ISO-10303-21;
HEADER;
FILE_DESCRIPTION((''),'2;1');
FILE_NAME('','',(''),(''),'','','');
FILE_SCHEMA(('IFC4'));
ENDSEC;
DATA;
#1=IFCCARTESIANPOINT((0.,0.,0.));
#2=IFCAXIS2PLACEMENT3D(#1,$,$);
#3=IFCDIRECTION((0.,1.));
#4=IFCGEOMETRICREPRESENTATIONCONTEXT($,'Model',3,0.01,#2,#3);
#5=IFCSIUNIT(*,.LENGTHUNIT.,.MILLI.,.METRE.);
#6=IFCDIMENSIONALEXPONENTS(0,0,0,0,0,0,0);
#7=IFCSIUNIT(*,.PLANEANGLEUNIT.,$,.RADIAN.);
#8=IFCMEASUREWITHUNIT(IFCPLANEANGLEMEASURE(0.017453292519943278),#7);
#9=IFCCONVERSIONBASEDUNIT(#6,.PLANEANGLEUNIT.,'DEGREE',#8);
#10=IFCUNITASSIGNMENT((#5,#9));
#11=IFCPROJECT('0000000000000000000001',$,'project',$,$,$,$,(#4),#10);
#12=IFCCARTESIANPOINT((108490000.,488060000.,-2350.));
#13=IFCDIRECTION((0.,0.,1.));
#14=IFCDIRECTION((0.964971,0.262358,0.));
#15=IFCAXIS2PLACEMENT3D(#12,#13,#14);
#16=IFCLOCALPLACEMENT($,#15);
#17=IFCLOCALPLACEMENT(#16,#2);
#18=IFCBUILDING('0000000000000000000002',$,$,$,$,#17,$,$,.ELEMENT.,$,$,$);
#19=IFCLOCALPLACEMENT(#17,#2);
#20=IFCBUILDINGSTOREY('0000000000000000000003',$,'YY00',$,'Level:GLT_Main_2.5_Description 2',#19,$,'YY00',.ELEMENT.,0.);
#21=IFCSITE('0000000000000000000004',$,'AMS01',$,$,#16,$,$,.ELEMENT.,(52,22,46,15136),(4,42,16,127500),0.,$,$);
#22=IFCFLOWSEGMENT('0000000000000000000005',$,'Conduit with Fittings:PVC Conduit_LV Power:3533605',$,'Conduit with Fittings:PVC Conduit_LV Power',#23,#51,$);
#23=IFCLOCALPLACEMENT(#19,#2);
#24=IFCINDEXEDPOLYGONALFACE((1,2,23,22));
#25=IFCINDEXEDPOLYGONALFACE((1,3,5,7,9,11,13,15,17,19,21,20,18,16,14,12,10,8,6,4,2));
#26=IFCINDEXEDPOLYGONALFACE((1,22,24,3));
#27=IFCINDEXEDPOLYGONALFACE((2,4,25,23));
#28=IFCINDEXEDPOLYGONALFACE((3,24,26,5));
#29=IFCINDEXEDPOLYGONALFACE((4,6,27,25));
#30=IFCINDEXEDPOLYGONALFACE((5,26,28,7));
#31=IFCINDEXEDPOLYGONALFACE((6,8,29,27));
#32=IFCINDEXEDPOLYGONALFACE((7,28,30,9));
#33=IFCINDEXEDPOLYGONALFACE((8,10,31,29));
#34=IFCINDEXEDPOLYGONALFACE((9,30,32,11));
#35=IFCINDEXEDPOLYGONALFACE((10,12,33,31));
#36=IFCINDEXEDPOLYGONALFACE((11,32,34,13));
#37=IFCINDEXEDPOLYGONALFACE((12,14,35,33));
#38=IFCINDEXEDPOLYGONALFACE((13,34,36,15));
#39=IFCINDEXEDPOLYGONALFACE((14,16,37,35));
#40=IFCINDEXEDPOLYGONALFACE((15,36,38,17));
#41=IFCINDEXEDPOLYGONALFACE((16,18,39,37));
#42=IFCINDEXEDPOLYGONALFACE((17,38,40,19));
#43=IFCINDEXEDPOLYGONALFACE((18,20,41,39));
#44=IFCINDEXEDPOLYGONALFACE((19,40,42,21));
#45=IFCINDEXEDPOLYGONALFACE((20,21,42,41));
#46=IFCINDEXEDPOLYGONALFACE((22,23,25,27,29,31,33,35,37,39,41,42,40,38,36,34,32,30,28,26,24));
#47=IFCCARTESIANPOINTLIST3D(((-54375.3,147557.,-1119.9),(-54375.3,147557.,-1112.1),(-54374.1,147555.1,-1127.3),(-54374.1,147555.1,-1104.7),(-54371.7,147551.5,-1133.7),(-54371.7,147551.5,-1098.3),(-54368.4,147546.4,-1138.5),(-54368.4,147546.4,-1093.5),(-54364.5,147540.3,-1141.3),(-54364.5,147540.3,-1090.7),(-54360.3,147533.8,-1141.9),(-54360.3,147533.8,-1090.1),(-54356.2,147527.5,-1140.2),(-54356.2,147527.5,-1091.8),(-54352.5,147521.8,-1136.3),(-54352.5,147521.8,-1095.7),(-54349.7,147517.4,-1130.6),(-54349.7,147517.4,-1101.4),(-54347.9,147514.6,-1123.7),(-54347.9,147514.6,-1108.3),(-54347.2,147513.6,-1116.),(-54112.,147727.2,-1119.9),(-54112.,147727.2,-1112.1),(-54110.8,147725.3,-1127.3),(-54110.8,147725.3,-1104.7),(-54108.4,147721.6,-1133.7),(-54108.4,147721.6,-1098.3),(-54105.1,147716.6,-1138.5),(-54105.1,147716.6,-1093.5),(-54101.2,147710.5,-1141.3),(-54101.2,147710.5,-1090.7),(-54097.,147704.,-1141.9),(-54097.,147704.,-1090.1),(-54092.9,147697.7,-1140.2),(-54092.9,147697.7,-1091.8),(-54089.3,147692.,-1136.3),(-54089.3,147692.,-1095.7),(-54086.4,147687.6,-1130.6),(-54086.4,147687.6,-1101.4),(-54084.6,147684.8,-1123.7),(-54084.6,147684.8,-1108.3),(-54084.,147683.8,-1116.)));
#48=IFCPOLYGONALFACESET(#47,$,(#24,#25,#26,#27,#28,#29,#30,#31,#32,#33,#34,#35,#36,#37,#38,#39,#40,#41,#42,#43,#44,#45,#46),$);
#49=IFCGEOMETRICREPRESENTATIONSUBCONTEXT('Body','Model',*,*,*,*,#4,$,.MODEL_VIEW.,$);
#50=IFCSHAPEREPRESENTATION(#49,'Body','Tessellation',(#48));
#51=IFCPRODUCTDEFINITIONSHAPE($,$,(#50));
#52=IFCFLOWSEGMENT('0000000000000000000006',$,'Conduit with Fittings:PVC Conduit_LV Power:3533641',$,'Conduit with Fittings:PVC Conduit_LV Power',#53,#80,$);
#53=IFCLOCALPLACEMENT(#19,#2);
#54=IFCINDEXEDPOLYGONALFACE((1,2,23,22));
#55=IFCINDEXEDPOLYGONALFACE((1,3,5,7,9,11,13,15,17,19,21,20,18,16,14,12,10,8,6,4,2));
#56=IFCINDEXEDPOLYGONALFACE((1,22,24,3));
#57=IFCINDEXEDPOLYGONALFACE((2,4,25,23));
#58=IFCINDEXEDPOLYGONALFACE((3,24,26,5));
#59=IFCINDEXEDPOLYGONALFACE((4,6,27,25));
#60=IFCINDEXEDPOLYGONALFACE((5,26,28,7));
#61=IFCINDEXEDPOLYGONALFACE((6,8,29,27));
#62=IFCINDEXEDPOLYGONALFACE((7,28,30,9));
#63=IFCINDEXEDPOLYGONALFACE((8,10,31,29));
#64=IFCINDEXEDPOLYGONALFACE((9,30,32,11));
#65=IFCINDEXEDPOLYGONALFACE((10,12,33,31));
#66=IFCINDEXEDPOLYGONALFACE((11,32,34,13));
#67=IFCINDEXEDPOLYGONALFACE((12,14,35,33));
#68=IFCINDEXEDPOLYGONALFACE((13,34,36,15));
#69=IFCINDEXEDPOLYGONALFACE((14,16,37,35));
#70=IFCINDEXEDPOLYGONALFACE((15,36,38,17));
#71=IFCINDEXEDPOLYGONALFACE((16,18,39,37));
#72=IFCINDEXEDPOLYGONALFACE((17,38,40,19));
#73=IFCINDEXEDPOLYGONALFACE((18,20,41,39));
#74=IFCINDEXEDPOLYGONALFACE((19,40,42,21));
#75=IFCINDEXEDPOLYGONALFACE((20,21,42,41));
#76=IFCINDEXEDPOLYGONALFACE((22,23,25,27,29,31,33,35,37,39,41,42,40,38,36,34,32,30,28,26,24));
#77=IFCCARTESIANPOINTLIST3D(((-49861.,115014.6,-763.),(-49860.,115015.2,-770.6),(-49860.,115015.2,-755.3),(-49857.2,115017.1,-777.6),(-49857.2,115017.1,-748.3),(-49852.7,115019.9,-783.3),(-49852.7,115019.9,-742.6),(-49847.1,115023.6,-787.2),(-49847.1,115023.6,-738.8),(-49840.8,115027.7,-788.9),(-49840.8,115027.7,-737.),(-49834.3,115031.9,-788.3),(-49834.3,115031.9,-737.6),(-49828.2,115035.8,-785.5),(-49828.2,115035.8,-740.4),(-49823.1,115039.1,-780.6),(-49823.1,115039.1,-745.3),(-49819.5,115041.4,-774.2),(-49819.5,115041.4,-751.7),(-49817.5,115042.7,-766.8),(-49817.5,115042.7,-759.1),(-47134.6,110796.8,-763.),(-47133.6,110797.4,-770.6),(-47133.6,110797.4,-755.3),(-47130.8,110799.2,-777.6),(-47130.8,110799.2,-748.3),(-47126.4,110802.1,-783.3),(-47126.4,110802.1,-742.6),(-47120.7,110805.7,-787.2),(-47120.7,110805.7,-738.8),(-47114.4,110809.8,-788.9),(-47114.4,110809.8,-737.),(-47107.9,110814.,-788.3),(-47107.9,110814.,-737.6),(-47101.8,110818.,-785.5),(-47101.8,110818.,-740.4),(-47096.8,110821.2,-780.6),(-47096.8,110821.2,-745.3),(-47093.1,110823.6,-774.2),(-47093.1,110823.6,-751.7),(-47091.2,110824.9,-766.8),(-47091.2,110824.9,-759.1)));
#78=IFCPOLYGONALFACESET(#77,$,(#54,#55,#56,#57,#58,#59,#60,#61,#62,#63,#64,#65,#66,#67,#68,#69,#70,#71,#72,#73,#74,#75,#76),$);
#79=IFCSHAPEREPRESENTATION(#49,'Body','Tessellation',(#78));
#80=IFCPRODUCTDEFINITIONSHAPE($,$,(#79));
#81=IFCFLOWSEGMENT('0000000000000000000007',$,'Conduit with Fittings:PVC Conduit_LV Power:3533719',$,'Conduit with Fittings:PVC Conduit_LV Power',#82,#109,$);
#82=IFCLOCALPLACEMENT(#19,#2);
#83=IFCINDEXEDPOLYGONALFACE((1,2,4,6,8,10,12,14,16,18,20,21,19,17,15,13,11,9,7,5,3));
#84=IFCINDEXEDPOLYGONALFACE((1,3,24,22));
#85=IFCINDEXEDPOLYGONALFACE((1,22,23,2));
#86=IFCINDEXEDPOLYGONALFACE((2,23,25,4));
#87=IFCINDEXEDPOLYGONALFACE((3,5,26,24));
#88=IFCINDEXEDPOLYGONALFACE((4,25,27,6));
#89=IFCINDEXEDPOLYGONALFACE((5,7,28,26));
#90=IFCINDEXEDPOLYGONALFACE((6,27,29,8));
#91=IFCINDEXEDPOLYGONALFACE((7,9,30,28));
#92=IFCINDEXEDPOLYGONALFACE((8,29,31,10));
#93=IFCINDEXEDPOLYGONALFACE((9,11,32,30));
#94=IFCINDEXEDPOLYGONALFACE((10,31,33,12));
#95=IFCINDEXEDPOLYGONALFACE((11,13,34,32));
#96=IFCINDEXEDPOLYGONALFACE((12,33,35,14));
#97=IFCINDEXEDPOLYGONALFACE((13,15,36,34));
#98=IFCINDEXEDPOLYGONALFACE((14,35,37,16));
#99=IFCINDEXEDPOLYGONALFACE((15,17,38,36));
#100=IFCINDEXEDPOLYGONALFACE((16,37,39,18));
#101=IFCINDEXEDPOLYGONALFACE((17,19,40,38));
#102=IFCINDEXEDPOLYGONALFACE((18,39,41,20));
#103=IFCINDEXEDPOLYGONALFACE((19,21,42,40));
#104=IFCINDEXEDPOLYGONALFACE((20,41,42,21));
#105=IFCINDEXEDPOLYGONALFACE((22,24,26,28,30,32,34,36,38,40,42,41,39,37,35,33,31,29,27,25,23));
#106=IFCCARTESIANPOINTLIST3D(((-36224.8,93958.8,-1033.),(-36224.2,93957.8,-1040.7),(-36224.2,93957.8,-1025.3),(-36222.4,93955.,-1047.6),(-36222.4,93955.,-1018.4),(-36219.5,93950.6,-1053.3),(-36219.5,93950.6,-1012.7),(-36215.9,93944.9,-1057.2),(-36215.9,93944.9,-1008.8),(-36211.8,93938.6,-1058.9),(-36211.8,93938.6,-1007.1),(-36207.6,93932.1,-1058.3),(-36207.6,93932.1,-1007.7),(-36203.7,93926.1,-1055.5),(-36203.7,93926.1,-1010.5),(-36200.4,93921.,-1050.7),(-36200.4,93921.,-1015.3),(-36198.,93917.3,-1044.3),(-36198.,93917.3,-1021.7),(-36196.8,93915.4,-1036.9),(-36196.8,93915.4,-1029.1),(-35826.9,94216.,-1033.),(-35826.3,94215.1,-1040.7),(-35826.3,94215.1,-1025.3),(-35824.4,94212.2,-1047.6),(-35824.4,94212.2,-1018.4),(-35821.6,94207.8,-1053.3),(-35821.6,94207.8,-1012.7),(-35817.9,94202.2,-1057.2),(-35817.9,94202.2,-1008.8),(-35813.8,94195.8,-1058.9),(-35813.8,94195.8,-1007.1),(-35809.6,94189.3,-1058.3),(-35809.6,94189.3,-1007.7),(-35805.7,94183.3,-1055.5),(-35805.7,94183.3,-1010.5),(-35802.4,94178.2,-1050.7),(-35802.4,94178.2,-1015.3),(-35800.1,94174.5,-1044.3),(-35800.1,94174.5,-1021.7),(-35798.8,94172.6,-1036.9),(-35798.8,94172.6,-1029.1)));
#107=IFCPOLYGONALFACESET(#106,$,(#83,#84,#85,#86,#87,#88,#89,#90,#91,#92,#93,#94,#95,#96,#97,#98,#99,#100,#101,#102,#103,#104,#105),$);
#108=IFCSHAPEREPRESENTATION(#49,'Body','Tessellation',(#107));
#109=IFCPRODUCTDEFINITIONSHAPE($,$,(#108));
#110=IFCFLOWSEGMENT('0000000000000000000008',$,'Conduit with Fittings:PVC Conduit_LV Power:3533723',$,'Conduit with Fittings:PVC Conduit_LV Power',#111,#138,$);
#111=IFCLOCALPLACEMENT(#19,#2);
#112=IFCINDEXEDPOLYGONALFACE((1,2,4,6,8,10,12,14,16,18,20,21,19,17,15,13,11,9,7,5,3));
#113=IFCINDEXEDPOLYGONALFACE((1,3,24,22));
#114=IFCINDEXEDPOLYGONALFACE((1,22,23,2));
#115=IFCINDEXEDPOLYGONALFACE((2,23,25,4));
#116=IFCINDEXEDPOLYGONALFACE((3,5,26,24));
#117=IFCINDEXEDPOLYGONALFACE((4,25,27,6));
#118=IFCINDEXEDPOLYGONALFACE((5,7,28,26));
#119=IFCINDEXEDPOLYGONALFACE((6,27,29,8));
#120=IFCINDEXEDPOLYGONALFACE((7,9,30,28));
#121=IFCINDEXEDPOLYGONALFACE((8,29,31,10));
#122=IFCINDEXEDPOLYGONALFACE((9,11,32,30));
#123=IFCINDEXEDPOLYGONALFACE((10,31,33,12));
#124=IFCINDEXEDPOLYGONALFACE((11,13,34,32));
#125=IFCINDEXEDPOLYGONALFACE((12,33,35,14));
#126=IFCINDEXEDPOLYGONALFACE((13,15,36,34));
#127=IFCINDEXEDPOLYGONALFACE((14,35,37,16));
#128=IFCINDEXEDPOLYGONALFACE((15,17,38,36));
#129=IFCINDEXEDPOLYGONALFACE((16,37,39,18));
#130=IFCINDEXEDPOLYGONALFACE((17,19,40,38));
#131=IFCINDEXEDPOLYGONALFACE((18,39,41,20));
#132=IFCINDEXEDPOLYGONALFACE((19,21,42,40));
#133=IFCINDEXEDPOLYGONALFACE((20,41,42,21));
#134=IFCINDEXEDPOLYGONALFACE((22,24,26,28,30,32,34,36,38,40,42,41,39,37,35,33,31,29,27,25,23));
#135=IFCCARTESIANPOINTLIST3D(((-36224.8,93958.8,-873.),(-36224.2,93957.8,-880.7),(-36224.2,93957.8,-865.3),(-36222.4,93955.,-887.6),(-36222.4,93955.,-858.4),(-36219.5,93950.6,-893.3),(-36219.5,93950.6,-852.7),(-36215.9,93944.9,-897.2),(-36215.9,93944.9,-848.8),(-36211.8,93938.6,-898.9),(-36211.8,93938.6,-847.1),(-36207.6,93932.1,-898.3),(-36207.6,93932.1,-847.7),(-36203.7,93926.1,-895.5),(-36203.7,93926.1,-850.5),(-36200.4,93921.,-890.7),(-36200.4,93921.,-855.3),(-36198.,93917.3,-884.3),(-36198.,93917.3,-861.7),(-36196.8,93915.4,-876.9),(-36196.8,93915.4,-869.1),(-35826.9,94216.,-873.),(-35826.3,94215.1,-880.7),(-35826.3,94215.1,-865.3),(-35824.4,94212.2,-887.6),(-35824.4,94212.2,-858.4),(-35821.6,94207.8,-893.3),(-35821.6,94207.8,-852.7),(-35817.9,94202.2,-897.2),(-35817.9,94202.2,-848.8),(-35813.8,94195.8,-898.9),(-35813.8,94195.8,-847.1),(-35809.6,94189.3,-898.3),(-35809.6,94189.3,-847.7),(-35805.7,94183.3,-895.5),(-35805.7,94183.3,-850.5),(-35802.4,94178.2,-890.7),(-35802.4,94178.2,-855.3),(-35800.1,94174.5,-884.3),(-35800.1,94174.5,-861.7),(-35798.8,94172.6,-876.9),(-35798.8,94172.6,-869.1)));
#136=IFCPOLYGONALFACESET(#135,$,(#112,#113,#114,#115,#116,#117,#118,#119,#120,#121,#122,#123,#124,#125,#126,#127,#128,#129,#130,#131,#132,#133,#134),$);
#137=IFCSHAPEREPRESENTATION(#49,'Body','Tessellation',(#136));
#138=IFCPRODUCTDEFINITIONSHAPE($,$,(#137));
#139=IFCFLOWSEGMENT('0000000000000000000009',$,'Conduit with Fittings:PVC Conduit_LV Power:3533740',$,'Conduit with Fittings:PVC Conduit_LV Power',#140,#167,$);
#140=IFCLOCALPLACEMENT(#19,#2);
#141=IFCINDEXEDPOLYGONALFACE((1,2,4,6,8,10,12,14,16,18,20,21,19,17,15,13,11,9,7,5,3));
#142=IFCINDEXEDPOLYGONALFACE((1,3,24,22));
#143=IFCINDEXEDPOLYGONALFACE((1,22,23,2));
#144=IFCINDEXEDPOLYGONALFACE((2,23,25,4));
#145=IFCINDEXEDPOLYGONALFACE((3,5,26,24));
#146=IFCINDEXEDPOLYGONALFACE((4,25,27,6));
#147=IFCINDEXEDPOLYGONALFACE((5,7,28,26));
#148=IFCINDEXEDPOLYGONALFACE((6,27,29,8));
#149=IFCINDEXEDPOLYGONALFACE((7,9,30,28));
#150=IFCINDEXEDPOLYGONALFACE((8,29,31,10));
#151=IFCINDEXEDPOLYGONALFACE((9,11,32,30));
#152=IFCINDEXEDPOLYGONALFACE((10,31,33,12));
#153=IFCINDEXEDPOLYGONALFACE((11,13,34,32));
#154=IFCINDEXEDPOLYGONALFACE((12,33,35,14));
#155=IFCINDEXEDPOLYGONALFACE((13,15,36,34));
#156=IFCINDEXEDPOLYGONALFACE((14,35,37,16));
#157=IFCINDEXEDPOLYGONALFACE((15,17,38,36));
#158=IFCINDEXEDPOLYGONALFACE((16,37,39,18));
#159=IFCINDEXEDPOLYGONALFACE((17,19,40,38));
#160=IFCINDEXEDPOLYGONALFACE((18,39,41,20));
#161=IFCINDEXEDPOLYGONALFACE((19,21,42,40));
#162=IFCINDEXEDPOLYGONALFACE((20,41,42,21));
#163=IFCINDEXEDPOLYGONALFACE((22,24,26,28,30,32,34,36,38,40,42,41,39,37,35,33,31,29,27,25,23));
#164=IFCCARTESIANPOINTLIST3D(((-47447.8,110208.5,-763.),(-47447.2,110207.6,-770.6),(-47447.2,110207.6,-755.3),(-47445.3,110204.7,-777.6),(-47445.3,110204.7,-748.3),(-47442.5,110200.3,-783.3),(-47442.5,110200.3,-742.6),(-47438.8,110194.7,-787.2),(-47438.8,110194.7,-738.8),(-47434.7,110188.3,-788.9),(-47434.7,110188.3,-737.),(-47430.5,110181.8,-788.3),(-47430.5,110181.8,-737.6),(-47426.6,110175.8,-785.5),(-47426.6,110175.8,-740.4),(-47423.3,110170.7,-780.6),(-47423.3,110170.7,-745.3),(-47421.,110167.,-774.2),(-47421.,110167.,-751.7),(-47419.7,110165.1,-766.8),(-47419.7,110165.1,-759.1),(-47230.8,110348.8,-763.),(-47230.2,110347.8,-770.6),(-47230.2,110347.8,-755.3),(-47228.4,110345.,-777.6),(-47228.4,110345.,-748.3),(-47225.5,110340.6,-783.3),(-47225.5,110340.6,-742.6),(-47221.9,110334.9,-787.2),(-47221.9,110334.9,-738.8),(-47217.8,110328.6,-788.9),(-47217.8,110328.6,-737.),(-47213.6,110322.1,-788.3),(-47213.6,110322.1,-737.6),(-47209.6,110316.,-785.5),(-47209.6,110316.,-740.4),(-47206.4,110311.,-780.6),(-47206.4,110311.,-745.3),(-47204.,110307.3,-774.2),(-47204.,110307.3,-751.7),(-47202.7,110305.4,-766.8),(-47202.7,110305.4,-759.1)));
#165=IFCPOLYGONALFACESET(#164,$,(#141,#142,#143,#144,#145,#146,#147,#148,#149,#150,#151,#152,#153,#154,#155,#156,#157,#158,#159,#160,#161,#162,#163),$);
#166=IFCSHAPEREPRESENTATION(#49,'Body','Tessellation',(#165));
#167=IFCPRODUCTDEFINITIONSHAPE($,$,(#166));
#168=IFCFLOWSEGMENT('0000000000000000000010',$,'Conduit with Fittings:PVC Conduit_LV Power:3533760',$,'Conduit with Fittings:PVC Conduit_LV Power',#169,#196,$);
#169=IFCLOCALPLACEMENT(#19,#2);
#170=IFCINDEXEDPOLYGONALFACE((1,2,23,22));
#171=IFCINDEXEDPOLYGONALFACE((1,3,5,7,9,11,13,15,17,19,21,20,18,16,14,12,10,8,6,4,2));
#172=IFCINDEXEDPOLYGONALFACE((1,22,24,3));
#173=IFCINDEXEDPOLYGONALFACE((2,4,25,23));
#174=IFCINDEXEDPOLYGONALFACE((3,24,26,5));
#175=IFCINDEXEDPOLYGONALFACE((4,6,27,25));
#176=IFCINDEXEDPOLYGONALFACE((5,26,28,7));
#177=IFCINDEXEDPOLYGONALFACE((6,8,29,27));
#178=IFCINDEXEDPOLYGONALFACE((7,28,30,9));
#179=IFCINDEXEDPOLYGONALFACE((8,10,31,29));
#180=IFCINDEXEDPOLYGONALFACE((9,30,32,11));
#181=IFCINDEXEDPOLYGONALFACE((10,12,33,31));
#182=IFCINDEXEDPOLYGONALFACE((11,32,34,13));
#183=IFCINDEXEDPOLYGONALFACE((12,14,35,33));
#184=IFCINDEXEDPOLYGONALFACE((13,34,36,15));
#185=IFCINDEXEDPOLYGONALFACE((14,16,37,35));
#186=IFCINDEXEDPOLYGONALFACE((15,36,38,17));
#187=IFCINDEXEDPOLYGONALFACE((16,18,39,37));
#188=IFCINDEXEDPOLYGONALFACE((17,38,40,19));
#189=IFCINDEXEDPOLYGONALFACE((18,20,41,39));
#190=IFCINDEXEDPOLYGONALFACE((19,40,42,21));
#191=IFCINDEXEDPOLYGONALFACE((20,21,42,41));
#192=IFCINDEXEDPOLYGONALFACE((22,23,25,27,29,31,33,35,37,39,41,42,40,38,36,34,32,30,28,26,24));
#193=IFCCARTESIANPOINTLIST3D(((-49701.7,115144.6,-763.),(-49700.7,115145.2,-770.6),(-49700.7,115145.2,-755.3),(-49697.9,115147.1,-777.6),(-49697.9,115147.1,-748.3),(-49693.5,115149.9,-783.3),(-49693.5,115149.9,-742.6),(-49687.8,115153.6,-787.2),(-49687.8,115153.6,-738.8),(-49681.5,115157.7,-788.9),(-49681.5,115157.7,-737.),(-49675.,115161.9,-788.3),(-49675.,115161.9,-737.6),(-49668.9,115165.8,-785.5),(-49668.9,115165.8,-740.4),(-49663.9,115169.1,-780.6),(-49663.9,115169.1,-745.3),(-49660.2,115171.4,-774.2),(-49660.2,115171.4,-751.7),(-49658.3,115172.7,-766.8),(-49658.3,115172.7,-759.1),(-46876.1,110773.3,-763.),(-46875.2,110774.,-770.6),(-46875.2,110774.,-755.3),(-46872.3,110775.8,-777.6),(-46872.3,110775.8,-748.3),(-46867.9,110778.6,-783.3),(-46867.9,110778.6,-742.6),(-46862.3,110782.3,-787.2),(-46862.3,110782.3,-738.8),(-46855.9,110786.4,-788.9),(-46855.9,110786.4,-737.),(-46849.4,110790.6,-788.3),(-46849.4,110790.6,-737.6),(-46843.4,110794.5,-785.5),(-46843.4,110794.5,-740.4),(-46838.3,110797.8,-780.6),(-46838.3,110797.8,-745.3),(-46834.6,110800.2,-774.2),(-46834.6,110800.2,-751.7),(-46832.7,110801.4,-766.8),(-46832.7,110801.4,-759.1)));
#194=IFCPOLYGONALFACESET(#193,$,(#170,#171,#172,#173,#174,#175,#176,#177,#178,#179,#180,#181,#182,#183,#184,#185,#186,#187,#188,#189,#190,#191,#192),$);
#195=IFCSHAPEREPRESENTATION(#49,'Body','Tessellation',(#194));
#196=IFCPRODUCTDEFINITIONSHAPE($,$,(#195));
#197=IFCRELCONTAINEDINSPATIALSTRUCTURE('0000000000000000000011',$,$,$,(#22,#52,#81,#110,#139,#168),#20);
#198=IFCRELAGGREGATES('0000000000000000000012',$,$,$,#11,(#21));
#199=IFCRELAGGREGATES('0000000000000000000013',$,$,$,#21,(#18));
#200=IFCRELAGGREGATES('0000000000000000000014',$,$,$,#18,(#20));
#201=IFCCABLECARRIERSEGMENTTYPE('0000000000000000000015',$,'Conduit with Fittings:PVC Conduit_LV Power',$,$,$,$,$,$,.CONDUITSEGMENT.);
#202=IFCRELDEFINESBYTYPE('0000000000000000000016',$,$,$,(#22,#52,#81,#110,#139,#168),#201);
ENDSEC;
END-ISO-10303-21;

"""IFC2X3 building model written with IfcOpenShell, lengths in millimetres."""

from ifc_helpers import new_model, entity, si_unit, converted_unit, direction, frame, frame_2d, origin, origin_2d_with_axis, place, context, subcontext, project, spatial, circle, extrude, type_object, element, save


model = new_model("IFC2X3")

# Units and contexts
model_context = context("Model", 3, precision=0.01, world=origin(), true_north=direction((0.0, 1.0)))
body_context = subcontext(model_context, "Body", "Model", "MODEL_VIEW")
ifc_project = project(units=[si_unit("LENGTHUNIT", "METRE", prefix="MILLI"), converted_unit("PLANEANGLEUNIT", "DEGREE", entity("IfcPlaneAngleMeasure", 0.017453292519943278), si_unit("PLANEANGLEUNIT", "RADIAN"), dimensions=[0, 0, 0, 0, 0, 0, 0])], contexts=[model_context])

# Site, building, storey
site_placement = place(None, frame((108490000.0, 488060000.0, -2350.0), z_axis=(0.0, 0.0, 1.0), x_axis=(0.964971, 0.262358, 0.0)))
site = spatial("IfcSite", under=ifc_project, at=site_placement, Name="AMS01", CompositionType="ELEMENT", RefLatitude=(52, 22, 46, 15136), RefLongitude=(4, 42, 16, 127500), RefElevation=0.0)
building_placement = place(site_placement, origin())
building = spatial("IfcBuilding", under=site, at=building_placement, CompositionType="ELEMENT")
storey_placement = place(building_placement, origin())
storey = spatial("IfcBuildingStorey", under=building, at=storey_placement, Name="YY00", ObjectType="Level:GLT_Main_2.5_Description 2", LongName="YY00", CompositionType="ELEMENT", Elevation=0.0)

# Flow segments
cable_carrier_segment_type = type_object("IfcCableCarrierSegmentType", Name="Conduit with Fittings:PVC Conduit_LV Power", PredefinedType="CONDUITSEGMENT")
flow_segment_1_placement = place(storey_placement, origin())
element("IfcFlowSegment", 1, at=flow_segment_1_placement, inside=storey, type_object=cable_carrier_segment_type, Name="Conduit with Fittings:PVC Conduit_LV Power:3533605", ObjectType="Conduit with Fittings:PVC Conduit_LV Power", context=body_context, shape_type="SweptSolid", body=[
    extrude(circle(Radius=26.0, at=origin_2d_with_axis()), frame((-54361.3, 147535.5, -1116.0), z_axis=(0.839796, 0.542902, 0.0), x_axis=(0.542902, -0.839796, 0.0)), (0.0, 0.0, 1.0), 313.5),
])
flow_segment_2_placement = place(storey_placement, origin())
element("IfcFlowSegment", 2, at=flow_segment_2_placement, inside=storey, type_object=cable_carrier_segment_type, Name="Conduit with Fittings:PVC Conduit_LV Power:3533641", ObjectType="Conduit with Fittings:PVC Conduit_LV Power", context=body_context, shape_type="SweptSolid", body=[
    extrude(circle(Radius=26.0, at=frame_2d((0.0, 0.0), x_axis=(1.0, 0.0))), frame((-47112.8, 110810.9, -763.0), z_axis=(-0.542856, 0.839826, 0.0), x_axis=(-0.839826, -0.542856, 0.0)), (0.0, 0.0, 1.0), 5022.3),
])
flow_segment_3_placement = place(storey_placement, origin())
element("IfcFlowSegment", 3, at=flow_segment_3_placement, inside=storey, type_object=cable_carrier_segment_type, Name="Conduit with Fittings:PVC Conduit_LV Power:3533719", ObjectType="Conduit with Fittings:PVC Conduit_LV Power", context=body_context, shape_type="SweptSolid", body=[
    extrude(circle(Radius=26.0, at=frame_2d((0.0, 0.0), x_axis=(1.0, 0.0))), frame((-36210.7, 93937.0, -1033.0), z_axis=(0.839826, 0.542856, 0.0), x_axis=(-0.542856, 0.839826, 0.0)), (0.0, 0.0, 1.0), 473.8),
])
flow_segment_4_placement = place(storey_placement, origin())
element("IfcFlowSegment", 4, at=flow_segment_4_placement, inside=storey, type_object=cable_carrier_segment_type, Name="Conduit with Fittings:PVC Conduit_LV Power:3533723", ObjectType="Conduit with Fittings:PVC Conduit_LV Power", context=body_context, shape_type="SweptSolid", body=[
    extrude(circle(Radius=26.0, at=frame_2d((0.0, 0.0), x_axis=(1.0, 0.0))), frame((-36210.7, 93937.0, -873.0), z_axis=(0.839826, 0.542856, 0.0), x_axis=(-0.542856, 0.839826, 0.0)), (0.0, 0.0, 1.0), 473.8),
])
flow_segment_5_placement = place(storey_placement, origin())
element("IfcFlowSegment", 5, at=flow_segment_5_placement, inside=storey, type_object=cable_carrier_segment_type, Name="Conduit with Fittings:PVC Conduit_LV Power:3533740", ObjectType="Conduit with Fittings:PVC Conduit_LV Power", context=body_context, shape_type="SweptSolid", body=[
    extrude(circle(Radius=26.0, at=frame_2d((0.0, 0.0), x_axis=(1.0, 0.0))), frame((-47433.7, 110186.7, -763.0), z_axis=(0.839826, 0.542856, 0.0), x_axis=(-0.542856, 0.839826, 0.0)), (0.0, 0.0, 1.0), 258.4),
])
flow_segment_6_placement = place(storey_placement, origin())
element("IfcFlowSegment", 6, at=flow_segment_6_placement, inside=storey, type_object=cable_carrier_segment_type, Name="Conduit with Fittings:PVC Conduit_LV Power:3533760", ObjectType="Conduit with Fittings:PVC Conduit_LV Power", context=body_context, shape_type="SweptSolid", body=[
    extrude(circle(Radius=26.0, at=origin_2d_with_axis()), frame((-49679.9, 115158.7, -763.0), z_axis=(0.542856, -0.839826, 0.0), x_axis=(-0.839826, -0.542856, 0.0)), (0.0, 0.0, 1.0), 5205.0),
])

save(model, "model.ifc")
